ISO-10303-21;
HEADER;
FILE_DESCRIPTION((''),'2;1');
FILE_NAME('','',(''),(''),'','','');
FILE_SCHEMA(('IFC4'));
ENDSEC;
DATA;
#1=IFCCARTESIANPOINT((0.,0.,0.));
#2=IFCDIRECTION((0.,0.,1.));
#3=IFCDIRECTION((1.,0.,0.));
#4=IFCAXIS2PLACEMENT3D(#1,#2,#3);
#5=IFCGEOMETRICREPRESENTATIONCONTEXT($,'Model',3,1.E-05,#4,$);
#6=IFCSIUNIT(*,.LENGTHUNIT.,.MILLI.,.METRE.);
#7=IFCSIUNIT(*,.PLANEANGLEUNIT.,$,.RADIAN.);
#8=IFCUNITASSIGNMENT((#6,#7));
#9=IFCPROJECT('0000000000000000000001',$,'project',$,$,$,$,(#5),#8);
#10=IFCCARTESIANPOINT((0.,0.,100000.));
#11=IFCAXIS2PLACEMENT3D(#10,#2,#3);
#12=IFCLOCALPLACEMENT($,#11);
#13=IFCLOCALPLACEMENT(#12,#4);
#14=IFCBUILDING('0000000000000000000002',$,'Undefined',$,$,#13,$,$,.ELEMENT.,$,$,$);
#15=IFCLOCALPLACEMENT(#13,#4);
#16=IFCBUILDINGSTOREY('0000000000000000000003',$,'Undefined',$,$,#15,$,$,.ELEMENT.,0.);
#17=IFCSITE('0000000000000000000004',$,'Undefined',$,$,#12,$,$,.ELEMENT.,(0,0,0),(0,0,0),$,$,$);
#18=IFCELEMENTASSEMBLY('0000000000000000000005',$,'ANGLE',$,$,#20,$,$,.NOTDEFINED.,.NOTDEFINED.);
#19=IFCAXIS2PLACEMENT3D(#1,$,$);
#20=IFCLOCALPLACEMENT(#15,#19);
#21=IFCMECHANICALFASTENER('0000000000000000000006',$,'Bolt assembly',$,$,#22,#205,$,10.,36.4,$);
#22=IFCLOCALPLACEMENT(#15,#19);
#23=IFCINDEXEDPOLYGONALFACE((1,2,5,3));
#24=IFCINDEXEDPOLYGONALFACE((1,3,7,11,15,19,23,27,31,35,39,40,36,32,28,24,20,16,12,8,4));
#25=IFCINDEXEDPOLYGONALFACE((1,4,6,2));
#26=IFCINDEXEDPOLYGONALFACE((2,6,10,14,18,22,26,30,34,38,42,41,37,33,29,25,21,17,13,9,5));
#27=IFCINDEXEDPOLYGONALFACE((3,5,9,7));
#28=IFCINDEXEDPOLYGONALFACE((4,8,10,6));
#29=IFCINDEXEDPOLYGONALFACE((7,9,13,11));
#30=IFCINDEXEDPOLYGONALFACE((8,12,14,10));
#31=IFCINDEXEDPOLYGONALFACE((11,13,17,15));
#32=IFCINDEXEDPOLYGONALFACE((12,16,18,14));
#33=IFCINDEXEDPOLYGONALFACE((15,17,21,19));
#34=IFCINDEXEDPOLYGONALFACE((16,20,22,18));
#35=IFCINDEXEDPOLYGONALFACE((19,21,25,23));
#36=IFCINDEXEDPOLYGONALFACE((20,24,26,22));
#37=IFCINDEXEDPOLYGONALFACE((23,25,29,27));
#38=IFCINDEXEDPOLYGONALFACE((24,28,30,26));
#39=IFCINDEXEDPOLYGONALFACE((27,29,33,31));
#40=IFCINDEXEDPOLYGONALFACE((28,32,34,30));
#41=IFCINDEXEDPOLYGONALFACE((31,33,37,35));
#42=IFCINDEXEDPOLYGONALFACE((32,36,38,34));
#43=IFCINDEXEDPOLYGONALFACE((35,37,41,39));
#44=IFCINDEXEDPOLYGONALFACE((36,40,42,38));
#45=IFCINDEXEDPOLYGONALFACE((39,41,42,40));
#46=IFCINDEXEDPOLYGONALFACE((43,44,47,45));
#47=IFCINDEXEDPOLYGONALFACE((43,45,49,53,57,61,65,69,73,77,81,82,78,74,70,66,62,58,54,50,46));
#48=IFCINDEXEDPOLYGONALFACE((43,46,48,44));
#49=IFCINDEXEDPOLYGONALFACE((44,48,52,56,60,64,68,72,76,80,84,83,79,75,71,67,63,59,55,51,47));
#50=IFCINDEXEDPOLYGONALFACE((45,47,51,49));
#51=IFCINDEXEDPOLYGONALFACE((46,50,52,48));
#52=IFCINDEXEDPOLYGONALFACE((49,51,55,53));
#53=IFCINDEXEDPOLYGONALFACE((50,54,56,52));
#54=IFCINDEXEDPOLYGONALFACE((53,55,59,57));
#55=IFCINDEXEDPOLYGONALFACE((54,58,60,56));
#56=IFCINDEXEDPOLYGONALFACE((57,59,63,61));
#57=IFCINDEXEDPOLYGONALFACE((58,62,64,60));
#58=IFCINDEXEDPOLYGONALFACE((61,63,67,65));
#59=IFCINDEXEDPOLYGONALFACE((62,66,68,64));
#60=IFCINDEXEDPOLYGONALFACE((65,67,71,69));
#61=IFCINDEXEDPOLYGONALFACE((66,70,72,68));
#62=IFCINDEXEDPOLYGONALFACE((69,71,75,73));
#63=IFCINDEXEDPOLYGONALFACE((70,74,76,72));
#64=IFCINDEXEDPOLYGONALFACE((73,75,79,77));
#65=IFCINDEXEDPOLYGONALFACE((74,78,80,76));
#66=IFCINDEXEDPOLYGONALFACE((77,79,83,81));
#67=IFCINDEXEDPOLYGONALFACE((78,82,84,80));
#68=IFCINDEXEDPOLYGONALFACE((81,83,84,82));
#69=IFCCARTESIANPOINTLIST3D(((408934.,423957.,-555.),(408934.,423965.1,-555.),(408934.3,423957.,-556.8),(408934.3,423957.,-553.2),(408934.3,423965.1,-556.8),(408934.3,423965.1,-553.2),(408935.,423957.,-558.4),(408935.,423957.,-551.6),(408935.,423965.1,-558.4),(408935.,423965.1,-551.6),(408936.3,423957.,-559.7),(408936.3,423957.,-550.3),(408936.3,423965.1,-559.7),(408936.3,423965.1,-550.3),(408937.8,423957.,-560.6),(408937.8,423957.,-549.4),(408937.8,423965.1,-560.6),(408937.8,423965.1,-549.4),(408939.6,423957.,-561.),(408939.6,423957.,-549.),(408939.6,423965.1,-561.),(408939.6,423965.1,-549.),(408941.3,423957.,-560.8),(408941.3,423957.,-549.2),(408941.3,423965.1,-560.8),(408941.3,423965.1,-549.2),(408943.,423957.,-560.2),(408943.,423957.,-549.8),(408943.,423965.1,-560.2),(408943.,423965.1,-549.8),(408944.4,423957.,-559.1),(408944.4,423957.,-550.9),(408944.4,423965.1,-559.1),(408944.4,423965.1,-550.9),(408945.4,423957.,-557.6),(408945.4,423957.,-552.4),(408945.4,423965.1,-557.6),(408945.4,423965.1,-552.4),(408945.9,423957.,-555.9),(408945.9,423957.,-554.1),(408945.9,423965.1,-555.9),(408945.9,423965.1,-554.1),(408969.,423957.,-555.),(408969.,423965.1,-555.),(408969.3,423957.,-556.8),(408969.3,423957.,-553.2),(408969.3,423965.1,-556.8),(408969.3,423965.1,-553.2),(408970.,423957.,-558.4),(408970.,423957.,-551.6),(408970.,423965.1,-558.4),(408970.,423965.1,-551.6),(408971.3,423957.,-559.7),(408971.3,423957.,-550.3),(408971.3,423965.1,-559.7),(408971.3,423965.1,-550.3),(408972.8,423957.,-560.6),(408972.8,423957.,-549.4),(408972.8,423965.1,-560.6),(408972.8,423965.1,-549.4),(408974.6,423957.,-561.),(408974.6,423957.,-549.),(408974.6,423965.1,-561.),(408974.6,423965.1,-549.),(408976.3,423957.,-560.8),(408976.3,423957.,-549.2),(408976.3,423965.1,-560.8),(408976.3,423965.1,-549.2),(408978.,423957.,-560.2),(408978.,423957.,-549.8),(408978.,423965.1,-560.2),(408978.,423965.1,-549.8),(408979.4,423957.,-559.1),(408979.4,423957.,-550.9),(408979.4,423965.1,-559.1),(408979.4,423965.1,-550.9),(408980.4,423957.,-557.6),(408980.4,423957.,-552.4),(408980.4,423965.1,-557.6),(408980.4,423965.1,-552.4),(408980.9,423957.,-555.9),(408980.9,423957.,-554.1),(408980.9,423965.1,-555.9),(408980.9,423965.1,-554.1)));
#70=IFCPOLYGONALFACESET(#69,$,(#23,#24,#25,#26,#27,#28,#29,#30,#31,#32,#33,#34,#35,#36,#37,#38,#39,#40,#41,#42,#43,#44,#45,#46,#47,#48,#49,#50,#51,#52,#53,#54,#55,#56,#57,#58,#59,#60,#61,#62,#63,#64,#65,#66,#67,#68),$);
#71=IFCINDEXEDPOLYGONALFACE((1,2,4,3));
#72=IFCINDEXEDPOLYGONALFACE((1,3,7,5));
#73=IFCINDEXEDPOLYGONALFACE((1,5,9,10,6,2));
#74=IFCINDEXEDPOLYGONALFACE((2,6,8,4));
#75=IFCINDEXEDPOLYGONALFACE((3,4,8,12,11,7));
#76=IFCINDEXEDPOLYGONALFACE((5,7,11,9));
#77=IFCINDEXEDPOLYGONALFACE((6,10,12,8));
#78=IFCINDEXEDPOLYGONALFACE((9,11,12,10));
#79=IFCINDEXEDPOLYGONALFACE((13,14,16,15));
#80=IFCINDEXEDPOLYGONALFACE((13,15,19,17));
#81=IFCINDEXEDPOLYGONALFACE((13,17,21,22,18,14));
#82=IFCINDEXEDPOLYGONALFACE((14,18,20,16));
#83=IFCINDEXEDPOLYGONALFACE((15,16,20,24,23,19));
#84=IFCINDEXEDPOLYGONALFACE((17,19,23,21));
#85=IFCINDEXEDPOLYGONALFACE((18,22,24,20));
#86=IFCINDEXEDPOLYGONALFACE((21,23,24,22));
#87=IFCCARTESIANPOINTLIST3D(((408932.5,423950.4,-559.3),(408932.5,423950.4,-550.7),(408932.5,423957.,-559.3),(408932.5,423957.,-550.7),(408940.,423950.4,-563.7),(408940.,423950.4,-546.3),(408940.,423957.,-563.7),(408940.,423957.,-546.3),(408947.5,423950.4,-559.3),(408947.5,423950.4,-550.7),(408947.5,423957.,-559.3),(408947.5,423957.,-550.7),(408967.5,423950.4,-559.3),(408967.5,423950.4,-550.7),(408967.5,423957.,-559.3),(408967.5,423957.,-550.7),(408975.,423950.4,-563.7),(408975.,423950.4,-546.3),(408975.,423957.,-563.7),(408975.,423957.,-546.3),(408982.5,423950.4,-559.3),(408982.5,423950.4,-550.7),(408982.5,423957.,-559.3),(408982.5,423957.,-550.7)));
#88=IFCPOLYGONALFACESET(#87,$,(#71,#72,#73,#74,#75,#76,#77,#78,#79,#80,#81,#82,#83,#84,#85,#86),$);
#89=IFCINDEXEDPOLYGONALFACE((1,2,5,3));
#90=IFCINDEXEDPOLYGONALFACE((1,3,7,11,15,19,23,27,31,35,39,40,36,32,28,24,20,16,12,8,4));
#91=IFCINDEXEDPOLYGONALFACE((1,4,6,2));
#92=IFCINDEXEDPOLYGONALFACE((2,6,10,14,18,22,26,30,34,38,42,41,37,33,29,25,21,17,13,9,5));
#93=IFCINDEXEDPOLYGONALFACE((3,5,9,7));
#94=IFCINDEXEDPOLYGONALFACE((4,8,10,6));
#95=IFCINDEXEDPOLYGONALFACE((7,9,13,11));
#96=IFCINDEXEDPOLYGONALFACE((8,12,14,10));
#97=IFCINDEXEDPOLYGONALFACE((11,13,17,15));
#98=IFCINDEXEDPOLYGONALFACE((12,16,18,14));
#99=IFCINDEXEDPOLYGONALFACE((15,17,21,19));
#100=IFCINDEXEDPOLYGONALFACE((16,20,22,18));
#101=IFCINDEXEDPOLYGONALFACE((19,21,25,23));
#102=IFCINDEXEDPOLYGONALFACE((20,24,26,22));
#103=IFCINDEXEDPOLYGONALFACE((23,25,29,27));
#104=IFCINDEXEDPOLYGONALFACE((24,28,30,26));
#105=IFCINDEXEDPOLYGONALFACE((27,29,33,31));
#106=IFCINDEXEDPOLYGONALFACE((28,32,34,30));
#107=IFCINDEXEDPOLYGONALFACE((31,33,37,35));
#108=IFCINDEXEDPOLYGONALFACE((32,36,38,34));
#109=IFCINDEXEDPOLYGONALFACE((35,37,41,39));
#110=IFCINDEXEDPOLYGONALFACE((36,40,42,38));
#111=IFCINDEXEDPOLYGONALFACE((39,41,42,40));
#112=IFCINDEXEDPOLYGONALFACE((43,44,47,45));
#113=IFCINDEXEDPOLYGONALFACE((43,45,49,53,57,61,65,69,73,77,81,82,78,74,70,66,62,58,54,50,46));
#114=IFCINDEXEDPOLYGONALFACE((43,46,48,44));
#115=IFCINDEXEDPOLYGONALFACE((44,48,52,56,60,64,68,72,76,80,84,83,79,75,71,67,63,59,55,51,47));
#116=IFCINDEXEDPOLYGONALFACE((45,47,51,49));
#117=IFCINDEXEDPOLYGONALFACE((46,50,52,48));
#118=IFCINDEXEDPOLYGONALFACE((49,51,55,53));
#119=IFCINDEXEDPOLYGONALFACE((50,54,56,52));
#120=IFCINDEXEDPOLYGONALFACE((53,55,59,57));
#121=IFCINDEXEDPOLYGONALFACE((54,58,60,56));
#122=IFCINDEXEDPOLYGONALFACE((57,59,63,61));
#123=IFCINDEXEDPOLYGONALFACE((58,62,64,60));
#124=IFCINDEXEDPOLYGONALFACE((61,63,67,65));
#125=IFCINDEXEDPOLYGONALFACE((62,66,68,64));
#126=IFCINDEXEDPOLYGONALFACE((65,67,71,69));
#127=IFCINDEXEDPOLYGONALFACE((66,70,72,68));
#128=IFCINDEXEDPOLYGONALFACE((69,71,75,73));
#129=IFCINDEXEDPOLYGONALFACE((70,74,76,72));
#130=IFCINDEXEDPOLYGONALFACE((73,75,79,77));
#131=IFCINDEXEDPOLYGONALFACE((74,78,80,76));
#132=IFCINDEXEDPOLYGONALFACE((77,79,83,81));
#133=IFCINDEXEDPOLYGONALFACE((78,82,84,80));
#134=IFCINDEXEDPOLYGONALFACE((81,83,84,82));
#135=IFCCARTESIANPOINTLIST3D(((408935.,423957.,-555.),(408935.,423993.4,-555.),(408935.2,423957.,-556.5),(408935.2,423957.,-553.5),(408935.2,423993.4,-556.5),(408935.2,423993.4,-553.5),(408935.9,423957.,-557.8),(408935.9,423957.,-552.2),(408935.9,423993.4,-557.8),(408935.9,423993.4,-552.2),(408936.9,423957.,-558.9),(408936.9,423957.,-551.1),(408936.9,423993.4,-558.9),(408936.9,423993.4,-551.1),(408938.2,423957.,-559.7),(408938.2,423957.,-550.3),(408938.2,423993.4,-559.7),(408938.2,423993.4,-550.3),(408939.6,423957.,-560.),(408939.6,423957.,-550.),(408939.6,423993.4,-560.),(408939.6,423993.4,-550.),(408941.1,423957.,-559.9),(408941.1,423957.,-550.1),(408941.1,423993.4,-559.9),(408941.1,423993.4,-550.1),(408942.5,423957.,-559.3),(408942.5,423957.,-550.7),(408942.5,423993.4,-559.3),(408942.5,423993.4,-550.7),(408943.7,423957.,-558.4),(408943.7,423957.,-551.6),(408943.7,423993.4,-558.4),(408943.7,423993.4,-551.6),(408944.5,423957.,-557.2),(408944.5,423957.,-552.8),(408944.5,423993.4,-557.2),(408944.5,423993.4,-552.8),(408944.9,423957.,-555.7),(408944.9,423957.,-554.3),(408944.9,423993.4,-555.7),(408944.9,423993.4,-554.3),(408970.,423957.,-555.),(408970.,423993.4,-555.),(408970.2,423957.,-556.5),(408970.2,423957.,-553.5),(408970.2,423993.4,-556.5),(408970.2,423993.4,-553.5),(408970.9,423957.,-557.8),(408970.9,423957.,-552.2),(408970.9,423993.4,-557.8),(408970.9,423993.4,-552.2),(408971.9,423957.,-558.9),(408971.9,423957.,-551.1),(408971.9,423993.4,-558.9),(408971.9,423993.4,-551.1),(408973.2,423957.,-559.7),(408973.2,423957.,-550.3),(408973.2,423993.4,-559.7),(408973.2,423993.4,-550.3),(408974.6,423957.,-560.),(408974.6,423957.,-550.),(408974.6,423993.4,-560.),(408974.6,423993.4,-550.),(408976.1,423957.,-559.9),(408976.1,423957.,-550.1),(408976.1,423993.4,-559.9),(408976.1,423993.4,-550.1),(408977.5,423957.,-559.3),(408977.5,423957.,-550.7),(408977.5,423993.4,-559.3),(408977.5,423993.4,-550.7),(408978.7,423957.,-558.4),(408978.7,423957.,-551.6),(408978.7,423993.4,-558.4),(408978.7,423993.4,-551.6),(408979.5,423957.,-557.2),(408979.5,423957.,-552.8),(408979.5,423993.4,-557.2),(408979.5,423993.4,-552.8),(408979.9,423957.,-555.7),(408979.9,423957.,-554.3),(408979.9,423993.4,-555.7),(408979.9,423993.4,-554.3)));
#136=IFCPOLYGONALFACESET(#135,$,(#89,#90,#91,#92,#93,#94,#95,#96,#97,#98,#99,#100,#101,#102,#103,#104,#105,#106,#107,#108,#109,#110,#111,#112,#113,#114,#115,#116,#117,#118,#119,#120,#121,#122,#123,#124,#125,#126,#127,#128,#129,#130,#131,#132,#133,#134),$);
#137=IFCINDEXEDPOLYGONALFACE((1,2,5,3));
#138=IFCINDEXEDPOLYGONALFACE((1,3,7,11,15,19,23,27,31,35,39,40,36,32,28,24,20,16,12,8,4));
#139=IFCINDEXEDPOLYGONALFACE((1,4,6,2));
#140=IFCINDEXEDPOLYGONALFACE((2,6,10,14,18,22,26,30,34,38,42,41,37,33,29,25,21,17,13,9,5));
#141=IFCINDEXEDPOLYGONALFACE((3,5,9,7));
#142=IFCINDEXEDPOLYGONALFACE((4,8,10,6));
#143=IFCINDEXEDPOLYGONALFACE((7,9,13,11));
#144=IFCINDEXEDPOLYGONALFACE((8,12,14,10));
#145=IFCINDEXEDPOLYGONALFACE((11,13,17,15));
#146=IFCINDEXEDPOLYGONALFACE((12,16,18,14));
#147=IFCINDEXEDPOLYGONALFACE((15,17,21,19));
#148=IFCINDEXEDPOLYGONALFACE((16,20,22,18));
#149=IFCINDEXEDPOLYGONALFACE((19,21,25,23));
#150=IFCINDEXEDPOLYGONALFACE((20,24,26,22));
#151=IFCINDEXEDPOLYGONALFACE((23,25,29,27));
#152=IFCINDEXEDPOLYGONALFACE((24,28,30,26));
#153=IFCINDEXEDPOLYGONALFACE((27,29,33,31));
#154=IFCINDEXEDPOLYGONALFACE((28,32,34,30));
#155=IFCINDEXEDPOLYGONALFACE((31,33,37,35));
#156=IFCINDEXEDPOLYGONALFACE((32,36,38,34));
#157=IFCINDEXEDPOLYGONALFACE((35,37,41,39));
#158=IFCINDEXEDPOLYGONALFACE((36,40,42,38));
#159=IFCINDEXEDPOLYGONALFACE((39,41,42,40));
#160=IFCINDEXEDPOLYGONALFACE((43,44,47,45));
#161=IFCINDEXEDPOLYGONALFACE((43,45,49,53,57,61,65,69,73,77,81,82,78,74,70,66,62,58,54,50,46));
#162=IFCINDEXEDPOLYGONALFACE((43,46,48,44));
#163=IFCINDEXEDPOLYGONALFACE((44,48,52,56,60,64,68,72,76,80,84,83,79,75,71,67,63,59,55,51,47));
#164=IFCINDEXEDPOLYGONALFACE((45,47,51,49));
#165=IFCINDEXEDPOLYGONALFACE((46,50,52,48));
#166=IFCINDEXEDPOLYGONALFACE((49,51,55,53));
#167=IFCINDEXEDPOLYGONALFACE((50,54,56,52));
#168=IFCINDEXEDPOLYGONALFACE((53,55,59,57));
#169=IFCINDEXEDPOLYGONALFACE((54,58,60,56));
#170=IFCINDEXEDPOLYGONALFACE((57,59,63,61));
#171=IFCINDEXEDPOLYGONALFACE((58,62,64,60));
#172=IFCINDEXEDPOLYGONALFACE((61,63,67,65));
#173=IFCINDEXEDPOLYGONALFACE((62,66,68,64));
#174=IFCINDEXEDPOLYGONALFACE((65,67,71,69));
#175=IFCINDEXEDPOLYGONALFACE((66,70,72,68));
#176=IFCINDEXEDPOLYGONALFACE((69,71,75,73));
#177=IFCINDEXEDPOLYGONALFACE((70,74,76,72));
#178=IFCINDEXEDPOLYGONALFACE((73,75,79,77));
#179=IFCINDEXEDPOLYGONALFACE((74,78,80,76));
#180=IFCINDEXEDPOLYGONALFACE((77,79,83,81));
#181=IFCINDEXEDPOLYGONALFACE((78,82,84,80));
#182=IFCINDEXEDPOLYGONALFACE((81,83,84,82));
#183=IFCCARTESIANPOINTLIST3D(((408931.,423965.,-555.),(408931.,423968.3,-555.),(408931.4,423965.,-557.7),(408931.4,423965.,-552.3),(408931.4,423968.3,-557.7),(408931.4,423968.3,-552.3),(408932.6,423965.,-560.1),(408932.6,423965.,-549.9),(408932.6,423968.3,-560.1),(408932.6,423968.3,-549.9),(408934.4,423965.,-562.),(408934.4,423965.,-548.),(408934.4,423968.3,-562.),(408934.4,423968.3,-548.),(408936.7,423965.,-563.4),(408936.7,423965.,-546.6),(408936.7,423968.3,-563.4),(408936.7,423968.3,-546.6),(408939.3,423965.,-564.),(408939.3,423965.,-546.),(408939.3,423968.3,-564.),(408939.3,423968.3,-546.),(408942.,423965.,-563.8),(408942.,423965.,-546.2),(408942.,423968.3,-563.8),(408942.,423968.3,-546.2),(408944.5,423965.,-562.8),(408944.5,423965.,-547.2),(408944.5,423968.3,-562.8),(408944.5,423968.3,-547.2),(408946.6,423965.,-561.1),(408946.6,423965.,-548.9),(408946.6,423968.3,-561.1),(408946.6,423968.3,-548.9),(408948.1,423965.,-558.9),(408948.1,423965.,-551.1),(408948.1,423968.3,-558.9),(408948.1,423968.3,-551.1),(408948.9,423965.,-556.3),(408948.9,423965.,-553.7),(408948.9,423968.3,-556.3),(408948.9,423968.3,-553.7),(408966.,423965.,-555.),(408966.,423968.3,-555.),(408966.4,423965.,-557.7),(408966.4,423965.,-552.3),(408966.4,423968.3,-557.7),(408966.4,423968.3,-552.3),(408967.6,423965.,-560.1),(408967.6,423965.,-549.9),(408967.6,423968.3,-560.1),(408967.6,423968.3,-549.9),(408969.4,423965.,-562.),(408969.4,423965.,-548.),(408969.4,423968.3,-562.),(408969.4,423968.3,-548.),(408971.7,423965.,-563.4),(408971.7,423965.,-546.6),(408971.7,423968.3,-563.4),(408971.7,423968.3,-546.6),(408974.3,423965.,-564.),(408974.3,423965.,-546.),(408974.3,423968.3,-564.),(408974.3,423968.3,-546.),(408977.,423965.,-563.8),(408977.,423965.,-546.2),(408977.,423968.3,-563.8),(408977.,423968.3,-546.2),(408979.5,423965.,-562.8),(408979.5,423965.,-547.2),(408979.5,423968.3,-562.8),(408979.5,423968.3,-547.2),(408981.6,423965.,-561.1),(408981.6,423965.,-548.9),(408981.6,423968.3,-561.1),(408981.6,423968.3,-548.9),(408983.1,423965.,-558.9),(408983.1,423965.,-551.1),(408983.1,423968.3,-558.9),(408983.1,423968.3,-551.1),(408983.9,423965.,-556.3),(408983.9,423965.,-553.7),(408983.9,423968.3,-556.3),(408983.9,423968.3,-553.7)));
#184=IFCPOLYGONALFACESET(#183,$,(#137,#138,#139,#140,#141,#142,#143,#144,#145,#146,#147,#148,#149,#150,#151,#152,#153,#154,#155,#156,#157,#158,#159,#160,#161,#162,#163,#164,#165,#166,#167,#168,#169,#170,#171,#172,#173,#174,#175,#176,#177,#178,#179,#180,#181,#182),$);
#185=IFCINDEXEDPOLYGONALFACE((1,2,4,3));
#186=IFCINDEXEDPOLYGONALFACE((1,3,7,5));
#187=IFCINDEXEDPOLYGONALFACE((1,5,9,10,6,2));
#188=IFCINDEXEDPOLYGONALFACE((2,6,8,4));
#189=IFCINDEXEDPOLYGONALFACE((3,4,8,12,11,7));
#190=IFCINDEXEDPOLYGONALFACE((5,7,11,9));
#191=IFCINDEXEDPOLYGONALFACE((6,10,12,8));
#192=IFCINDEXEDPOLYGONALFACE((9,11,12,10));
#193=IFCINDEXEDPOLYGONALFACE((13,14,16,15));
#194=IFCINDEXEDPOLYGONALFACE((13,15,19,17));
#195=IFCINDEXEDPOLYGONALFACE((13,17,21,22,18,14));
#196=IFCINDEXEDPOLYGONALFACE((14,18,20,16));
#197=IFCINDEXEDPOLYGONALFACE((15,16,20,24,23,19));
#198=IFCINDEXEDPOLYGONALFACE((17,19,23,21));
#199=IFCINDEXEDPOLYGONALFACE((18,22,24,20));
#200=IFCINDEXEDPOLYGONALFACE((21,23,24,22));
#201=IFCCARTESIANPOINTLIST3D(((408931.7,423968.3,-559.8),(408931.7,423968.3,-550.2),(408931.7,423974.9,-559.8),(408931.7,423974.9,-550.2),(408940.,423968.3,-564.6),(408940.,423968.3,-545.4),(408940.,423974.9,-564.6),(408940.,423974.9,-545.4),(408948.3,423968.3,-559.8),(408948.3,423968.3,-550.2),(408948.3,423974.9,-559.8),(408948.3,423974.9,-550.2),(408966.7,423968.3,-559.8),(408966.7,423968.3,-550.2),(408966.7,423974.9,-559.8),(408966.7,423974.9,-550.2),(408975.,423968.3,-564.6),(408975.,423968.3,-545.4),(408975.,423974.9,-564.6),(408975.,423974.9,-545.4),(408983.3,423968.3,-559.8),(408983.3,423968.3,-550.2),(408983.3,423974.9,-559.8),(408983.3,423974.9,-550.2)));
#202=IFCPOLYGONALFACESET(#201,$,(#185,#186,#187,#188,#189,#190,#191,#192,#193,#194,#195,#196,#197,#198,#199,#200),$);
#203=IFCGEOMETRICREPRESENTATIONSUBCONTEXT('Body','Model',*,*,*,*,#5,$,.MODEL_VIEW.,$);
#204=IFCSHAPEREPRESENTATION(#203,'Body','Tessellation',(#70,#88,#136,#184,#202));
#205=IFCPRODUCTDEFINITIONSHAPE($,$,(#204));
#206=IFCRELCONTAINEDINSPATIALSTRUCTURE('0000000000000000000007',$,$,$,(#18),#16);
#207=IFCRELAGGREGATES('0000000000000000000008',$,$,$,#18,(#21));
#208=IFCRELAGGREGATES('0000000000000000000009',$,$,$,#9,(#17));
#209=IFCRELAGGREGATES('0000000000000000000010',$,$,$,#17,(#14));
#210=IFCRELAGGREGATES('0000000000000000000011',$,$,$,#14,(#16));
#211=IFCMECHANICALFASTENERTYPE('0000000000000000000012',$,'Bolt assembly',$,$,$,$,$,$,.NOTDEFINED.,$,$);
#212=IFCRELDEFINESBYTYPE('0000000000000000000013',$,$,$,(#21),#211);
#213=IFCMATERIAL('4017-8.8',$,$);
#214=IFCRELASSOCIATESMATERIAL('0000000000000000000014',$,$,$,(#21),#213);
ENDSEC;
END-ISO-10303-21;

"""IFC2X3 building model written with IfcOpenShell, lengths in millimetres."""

from ifc_helpers import new_model, si_unit, frame, origin_with_axes, origin_2d_with_axis, place, context, subcontext, project, spatial, polyline, circle, outline, extrude, source, transform, mapped, material, type_object, element, aggregate, save


model = new_model("IFC2X3")

# Units and contexts
model_context = context("Model", 3, precision=1e-05, world=origin_with_axes())
body_context = subcontext(model_context, "Body", "Model", "MODEL_VIEW")
ifc_project = project(units=[si_unit("LENGTHUNIT", "METRE", prefix="MILLI"), si_unit("PLANEANGLEUNIT", "RADIAN")], contexts=[model_context])

# Site, building, storey
site_placement = place(None, frame((0.0, 0.0, 100000.0), z_axis=(0.0, 0.0, 1.0), x_axis=(1.0, 0.0, 0.0)))
site = spatial("IfcSite", under=ifc_project, at=site_placement, Name="Undefined", CompositionType="ELEMENT", RefLatitude=(0, 0, 0), RefLongitude=(0, 0, 0))
building_placement = place(site_placement, origin_with_axes())
building = spatial("IfcBuilding", under=site, at=building_placement, Name="Undefined", CompositionType="ELEMENT")
storey_placement = place(building_placement, origin_with_axes())
storey = spatial("IfcBuildingStorey", under=building, at=storey_placement, Name="Undefined", CompositionType="ELEMENT", Elevation=0.0)

# Element assembly
assembly_1_placement = place(storey_placement, origin_with_axes())
assembly_1 = element("IfcElementAssembly", 1, at=assembly_1_placement, inside=storey, Name="ANGLE", AssemblyPlace="NOTDEFINED", PredefinedType="NOTDEFINED")

# Shared definitions
ifc_material_1 = material(Name="4017-8.8")
mechanical_fastener_type = type_object("IfcMechanicalFastenerType", Name="Bolt assembly")

# Mechanical fastener
shared_shape_1 = source(origin_with_axes(), body_context, "Body", "SweptSolid", [
    extrude(circle(Radius=6.0, at=origin_2d_with_axis()), frame((0.0, -8.0, 0.0), z_axis=(0.0, 1.0, 0.0), x_axis=(1.0, 0.0, 0.0)), (0.0, 0.0, 1.0), 8.1),
    extrude(outline(polyline([(7.5, -4.3), (7.5, 4.3), (0.0, 8.7), (-7.5, 4.3), (-7.5, -4.3), (0.0, -8.7), (7.5, -4.3)])), frame((0.0, -14.6, 0.0), z_axis=(0.0, 1.0, 0.0), x_axis=(1.0, 0.0, 0.0)), (0.0, 0.0, 1.0), 6.6),
    extrude(circle(Radius=5.0, at=origin_2d_with_axis()), frame((0.0, -8.0, 0.0), z_axis=(0.0, 1.0, 0.0), x_axis=(1.0, 0.0, 0.0)), (0.0, 0.0, 1.0), 36.4),
    extrude(circle(Radius=9.0, at=origin_2d_with_axis()), frame((0.0, 0.0, 0.0), z_axis=(0.0, 1.0, 0.0), x_axis=(1.0, 0.0, 0.0)), (0.0, 0.0, 1.0), 3.3),
    extrude(outline(polyline([(8.3, -4.8), (8.3, 4.8), (0.0, 9.6), (-8.3, 4.8), (-8.3, -4.8), (0.0, -9.6), (8.3, -4.8)])), frame((0.0, 3.3, 0.0), z_axis=(0.0, 1.0, 0.0), x_axis=(1.0, 0.0, 0.0)), (0.0, 0.0, 1.0), 6.6),
])
mechanical_fastener_1_placement = place(assembly_1_placement, frame((409000.0, 423965.0, -520.0), z_axis=(0.0, 0.0, -1.0), x_axis=(-1.0, 0.0, 0.0)))
mechanical_fastener_1 = element("IfcMechanicalFastener", 2, at=mechanical_fastener_1_placement, type_object=mechanical_fastener_type, material=ifc_material_1, Name="Bolt assembly", NominalDiameter=10.0, NominalLength=36.4, context=body_context, shape_type="MappedRepresentation", body=[
    mapped(shared_shape_1, transform((25.0, 0.0, 35.0))),
    mapped(shared_shape_1, transform((60.0, 0.0, 35.0))),
])
aggregate(assembly_1, [mechanical_fastener_1])

save(model, "model.ifc")
